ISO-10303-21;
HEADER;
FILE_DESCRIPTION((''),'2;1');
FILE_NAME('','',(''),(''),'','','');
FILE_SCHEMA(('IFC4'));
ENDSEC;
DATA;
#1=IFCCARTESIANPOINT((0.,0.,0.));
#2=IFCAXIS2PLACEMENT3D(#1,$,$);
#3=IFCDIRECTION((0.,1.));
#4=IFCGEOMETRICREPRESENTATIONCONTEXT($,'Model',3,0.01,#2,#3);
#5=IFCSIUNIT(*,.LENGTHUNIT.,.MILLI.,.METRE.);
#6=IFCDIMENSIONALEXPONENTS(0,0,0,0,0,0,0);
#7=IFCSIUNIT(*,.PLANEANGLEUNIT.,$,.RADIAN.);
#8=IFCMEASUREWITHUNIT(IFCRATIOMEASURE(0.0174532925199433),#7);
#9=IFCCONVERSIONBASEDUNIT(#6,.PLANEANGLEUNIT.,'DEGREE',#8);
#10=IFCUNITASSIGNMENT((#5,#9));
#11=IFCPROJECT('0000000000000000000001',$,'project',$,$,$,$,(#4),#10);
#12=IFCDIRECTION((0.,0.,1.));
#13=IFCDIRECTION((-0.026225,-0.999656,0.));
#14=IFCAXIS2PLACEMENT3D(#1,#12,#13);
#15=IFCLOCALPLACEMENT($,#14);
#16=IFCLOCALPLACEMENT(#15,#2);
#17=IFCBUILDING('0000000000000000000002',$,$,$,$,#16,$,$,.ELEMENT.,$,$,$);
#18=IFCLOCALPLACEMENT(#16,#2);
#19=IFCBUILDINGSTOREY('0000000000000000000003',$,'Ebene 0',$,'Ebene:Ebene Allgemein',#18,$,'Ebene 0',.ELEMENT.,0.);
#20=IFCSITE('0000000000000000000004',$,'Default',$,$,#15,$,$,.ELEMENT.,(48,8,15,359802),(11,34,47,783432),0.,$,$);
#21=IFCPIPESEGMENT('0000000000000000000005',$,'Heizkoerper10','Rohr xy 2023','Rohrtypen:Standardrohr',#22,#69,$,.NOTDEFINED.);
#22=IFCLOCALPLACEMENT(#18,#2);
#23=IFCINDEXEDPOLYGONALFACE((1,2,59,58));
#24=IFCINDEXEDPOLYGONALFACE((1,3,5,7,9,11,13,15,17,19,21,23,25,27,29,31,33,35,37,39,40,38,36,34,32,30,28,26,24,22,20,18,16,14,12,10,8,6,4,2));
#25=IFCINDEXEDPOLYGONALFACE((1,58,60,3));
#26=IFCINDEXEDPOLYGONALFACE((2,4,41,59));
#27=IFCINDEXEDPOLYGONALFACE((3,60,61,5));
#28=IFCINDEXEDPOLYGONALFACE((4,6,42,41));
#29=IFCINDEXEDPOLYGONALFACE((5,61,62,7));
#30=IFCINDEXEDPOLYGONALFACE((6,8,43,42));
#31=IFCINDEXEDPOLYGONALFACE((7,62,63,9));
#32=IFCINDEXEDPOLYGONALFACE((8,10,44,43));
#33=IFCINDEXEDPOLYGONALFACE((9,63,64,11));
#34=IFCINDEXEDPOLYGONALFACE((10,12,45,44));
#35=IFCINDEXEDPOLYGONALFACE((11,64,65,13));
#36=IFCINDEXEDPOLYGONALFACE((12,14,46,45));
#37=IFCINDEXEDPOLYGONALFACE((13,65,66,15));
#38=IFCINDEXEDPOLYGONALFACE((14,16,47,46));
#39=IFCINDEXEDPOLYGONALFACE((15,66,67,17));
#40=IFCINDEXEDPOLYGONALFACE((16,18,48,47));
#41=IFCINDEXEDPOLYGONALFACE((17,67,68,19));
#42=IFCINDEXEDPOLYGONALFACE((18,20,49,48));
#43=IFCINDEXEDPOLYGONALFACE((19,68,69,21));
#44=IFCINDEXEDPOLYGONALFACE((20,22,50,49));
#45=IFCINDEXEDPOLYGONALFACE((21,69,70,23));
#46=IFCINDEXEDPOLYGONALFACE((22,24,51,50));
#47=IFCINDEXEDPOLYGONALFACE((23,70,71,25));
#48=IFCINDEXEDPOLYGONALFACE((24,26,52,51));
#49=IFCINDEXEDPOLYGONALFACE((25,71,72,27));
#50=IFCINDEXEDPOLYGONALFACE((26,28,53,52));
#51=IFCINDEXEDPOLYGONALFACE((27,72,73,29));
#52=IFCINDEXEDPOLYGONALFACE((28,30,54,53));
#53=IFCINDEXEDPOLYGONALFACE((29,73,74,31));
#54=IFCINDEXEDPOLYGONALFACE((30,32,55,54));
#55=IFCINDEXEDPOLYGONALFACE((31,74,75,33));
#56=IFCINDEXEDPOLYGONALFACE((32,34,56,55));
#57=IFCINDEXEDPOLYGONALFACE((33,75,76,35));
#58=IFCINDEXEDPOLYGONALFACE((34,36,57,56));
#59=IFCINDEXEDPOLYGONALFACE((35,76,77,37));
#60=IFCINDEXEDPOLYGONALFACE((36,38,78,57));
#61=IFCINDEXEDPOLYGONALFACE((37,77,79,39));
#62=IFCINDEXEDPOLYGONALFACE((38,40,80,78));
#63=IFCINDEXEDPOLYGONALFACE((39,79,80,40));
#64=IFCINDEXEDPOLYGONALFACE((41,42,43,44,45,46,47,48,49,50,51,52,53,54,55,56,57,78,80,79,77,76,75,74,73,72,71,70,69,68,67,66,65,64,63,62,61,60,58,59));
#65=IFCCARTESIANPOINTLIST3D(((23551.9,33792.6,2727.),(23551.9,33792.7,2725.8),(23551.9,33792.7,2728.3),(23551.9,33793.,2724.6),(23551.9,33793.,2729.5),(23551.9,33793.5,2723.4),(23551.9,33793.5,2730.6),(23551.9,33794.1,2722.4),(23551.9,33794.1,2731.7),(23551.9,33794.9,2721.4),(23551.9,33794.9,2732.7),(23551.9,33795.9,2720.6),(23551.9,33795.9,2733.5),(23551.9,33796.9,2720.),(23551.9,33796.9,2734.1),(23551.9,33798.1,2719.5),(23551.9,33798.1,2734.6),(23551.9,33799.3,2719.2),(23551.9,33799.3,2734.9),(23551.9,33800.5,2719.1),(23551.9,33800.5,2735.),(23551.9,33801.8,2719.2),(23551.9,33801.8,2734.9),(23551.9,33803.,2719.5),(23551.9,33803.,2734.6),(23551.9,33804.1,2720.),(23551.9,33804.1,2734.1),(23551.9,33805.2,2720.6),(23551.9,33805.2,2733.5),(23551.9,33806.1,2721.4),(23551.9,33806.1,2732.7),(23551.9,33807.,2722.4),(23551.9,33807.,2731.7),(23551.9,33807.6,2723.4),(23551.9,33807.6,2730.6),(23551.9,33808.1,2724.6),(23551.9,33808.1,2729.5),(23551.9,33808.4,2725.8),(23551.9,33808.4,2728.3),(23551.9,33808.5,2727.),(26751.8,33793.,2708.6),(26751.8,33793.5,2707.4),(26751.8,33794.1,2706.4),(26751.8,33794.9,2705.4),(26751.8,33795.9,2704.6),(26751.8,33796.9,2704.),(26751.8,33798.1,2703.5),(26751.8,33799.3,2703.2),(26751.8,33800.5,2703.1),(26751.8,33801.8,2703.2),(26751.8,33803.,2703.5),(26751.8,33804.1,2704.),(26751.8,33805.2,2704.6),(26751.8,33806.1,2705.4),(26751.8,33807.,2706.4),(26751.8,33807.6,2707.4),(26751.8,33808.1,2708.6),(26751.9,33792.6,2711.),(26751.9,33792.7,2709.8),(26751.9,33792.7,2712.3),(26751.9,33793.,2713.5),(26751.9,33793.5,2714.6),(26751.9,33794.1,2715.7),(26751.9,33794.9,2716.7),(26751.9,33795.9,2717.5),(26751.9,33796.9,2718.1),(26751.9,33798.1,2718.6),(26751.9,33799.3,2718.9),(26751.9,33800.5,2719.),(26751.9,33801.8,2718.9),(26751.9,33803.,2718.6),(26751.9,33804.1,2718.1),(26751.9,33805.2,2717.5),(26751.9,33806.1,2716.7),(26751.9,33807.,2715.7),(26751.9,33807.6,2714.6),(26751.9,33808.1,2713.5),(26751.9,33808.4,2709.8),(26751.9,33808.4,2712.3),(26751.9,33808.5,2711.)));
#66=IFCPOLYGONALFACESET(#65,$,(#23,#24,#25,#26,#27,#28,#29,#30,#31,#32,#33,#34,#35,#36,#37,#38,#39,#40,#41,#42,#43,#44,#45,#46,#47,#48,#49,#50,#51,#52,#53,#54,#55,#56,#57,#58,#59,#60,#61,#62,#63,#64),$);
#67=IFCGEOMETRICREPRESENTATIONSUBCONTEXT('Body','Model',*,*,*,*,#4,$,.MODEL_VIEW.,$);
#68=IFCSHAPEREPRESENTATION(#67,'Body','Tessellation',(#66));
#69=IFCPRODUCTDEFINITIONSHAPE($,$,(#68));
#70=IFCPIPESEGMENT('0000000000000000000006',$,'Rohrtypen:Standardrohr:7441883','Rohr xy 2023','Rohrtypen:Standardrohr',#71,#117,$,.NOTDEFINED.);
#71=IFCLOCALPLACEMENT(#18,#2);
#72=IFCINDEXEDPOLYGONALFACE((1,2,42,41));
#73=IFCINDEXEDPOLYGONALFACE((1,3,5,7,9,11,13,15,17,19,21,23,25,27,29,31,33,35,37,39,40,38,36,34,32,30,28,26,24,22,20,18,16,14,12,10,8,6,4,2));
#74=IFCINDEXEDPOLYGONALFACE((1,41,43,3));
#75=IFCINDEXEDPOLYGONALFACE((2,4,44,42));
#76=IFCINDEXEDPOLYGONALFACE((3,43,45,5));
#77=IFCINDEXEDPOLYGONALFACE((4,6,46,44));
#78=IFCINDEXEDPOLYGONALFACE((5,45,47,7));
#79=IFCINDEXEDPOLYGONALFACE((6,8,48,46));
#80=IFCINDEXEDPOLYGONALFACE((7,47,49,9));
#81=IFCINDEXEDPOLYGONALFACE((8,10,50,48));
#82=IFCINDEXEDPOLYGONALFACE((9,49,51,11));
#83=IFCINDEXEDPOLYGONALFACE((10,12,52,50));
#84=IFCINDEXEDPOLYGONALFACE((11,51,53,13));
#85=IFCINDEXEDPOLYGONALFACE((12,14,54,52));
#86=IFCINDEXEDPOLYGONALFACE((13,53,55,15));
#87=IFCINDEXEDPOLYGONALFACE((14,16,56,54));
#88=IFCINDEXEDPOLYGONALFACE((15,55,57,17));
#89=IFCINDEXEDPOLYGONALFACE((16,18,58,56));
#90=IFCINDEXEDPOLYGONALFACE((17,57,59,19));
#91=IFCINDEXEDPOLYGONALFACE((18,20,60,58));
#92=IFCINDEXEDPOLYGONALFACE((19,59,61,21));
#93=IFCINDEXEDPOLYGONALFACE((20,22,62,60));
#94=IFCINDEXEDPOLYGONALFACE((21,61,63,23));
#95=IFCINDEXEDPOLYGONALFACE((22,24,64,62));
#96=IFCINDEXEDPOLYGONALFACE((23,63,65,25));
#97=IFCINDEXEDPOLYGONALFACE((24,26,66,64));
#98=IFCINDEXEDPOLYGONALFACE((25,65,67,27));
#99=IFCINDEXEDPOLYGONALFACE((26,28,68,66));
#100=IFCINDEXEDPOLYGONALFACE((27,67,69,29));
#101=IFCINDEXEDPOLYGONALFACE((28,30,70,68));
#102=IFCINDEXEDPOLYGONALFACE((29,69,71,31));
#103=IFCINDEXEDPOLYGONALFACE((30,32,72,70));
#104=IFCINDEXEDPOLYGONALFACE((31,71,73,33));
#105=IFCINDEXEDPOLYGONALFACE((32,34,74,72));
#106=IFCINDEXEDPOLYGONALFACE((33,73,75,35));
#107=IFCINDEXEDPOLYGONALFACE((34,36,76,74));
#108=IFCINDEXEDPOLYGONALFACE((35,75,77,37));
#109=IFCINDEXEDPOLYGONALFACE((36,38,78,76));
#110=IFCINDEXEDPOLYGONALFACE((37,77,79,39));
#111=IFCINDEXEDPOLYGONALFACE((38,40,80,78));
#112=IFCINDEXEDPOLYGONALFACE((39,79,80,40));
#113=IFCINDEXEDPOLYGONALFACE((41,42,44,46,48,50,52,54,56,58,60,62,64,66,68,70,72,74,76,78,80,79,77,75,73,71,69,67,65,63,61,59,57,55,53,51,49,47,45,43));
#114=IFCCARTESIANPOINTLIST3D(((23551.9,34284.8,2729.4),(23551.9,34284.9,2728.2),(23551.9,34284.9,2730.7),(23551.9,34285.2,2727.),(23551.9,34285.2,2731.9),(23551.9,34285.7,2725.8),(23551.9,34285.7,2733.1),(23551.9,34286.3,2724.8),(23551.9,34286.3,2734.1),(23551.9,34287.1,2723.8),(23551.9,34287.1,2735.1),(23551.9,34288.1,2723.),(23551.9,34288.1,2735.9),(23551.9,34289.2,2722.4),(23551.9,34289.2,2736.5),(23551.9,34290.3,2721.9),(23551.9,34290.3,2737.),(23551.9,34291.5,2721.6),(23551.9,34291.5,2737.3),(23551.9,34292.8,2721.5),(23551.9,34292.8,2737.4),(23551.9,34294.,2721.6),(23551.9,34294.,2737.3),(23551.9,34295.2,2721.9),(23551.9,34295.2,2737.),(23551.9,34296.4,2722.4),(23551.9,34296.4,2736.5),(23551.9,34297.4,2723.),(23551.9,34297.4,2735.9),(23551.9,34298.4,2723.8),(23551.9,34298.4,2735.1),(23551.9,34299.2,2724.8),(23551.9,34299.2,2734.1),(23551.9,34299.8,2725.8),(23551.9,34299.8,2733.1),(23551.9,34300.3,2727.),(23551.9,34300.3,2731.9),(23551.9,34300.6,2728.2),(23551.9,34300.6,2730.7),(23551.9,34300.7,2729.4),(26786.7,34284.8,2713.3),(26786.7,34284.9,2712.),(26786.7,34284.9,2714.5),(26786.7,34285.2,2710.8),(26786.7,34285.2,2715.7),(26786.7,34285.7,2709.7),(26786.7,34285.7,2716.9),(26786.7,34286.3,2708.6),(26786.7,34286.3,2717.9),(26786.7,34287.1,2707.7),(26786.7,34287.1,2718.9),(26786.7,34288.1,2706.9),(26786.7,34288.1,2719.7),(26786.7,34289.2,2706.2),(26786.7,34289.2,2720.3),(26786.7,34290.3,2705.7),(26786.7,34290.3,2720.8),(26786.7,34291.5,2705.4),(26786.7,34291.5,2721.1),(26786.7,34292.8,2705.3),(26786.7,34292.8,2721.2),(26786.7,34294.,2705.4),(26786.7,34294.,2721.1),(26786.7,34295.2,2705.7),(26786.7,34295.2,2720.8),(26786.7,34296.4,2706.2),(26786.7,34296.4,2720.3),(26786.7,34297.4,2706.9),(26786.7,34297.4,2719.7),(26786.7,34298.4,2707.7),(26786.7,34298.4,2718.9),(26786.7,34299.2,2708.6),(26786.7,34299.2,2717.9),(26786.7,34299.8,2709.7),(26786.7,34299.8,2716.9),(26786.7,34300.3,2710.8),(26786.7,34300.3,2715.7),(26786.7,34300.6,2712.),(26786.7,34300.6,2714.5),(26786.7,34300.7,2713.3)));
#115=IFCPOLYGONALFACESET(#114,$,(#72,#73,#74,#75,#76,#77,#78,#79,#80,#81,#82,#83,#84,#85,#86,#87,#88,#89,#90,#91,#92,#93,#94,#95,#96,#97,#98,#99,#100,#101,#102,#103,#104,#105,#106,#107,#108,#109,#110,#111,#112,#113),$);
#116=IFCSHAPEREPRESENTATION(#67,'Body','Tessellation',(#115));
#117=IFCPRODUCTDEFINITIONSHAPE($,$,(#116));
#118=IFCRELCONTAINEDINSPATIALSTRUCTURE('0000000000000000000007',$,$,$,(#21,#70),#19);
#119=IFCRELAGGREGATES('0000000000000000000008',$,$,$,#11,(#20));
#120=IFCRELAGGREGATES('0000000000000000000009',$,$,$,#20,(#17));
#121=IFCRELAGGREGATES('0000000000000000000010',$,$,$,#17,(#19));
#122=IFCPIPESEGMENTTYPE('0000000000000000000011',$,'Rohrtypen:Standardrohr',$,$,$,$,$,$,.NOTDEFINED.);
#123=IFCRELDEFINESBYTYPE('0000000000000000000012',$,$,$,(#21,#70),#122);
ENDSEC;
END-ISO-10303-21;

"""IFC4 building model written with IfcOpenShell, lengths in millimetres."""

from ifc_helpers import new_model, entity, si_unit, converted_unit, direction, frame, origin, place, context, subcontext, project, spatial, indexed_curve, outline, extrude, type_object, element, save


model = new_model("IFC4")

# Units and contexts
model_context = context("Model", 3, precision=0.01, world=origin(), true_north=direction((0.0, 1.0)))
body_context = subcontext(model_context, "Body", "Model", "MODEL_VIEW")
ifc_project = project(units=[si_unit("LENGTHUNIT", "METRE", prefix="MILLI"), converted_unit("PLANEANGLEUNIT", "DEGREE", entity("IfcRatioMeasure", 0.0174532925199433), si_unit("PLANEANGLEUNIT", "RADIAN"), dimensions=[0, 0, 0, 0, 0, 0, 0])], contexts=[model_context])

# Site, building, storey
site_placement = place(None, frame((0.0, 0.0, 0.0), z_axis=(0.0, 0.0, 1.0), x_axis=(-0.026225, -0.999656, 0.0)))
site = spatial("IfcSite", under=ifc_project, at=site_placement, Name="Default", CompositionType="ELEMENT", RefLatitude=(48, 8, 15, 359802), RefLongitude=(11, 34, 47, 783432), RefElevation=0.0)
building_placement = place(site_placement, origin())
building = spatial("IfcBuilding", under=site, at=building_placement, CompositionType="ELEMENT")
storey_placement = place(building_placement, origin())
storey = spatial("IfcBuildingStorey", under=building, at=storey_placement, Name="Ebene 0", ObjectType="Ebene:Ebene Allgemein", LongName="Ebene 0", CompositionType="ELEMENT", Elevation=0.0)

# Pipe segments
pipe_segment_type = type_object("IfcPipeSegmentType", Name="Rohrtypen:Standardrohr", PredefinedType="NOTDEFINED")
pipe_segment_1_placement = place(storey_placement, origin())
element("IfcPipeSegment", 1, at=pipe_segment_1_placement, inside=storey, type_object=pipe_segment_type, Name="Heizkoerper10", Description="Rohr xy 2023", ObjectType="Rohrtypen:Standardrohr", PredefinedType="NOTDEFINED", context=body_context, shape_type="SweptSolid", body=[
    extrude(outline(indexed_curve([(7.9, 0.0), (7.8, 1.2), (7.6, 2.5), (7.1, 3.6), (6.4, 4.7), (5.6, 5.6), (4.7, 6.4), (3.6, 7.1), (2.5, 7.6), (1.2, 7.8), (0.0, 7.9), (-1.2, 7.8), (-2.5, 7.6), (-3.6, 7.1), (-4.7, 6.4), (-5.6, 5.6), (-6.4, 4.7), (-7.1, 3.6), (-7.6, 2.5), (-7.8, 1.2), (-7.9, 0.0), (-7.8, -1.2), (-7.6, -2.5), (-7.1, -3.6), (-6.4, -4.7), (-5.6, -5.6), (-4.7, -6.4), (-3.6, -7.1), (-2.5, -7.6), (-1.2, -7.8), (0.0, -7.9), (1.2, -7.8), (2.5, -7.6), (3.6, -7.1), (4.7, -6.4), (5.6, -5.6), (6.4, -4.7), (7.1, -3.6), (7.6, -2.5), (7.8, -1.2), (7.9, 0.0)], self_intersect=False)), frame((26751.9, 33800.5, 2711.0), z_axis=(-0.999988, 0.0, 0.005), x_axis=(0.0, 1.0, 0.0)), (0.0, 0.0, 1.0), 3200.0),
])
pipe_segment_2_placement = place(storey_placement, origin())
element("IfcPipeSegment", 2, at=pipe_segment_2_placement, inside=storey, type_object=pipe_segment_type, Name="Rohrtypen:Standardrohr:7441883", Description="Rohr xy 2023", ObjectType="Rohrtypen:Standardrohr", PredefinedType="NOTDEFINED", context=body_context, shape_type="SweptSolid", body=[
    extrude(outline(indexed_curve([(7.9, 0.0), (7.8, 1.2), (7.6, 2.5), (7.1, 3.6), (6.4, 4.7), (5.6, 5.6), (4.7, 6.4), (3.6, 7.1), (2.5, 7.6), (1.2, 7.8), (0.0, 7.9), (-1.2, 7.8), (-2.5, 7.6), (-3.6, 7.1), (-4.7, 6.4), (-5.6, 5.6), (-6.4, 4.7), (-7.1, 3.6), (-7.6, 2.5), (-7.8, 1.2), (-7.9, 0.0), (-7.8, -1.2), (-7.6, -2.5), (-7.1, -3.6), (-6.4, -4.7), (-5.6, -5.6), (-4.7, -6.4), (-3.6, -7.1), (-2.5, -7.6), (-1.2, -7.8), (0.0, -7.9), (1.2, -7.8), (2.5, -7.6), (3.6, -7.1), (4.7, -6.4), (5.6, -5.6), (6.4, -4.7), (7.1, -3.6), (7.6, -2.5), (7.8, -1.2), (7.9, 0.0)], self_intersect=False)), frame((26786.7, 34292.8, 2713.3), z_axis=(-0.999988, 0.0, 0.005), x_axis=(0.0, 1.0, 0.0)), (0.0, 0.0, 1.0), 3234.8),
])

save(model, "model.ifc")
